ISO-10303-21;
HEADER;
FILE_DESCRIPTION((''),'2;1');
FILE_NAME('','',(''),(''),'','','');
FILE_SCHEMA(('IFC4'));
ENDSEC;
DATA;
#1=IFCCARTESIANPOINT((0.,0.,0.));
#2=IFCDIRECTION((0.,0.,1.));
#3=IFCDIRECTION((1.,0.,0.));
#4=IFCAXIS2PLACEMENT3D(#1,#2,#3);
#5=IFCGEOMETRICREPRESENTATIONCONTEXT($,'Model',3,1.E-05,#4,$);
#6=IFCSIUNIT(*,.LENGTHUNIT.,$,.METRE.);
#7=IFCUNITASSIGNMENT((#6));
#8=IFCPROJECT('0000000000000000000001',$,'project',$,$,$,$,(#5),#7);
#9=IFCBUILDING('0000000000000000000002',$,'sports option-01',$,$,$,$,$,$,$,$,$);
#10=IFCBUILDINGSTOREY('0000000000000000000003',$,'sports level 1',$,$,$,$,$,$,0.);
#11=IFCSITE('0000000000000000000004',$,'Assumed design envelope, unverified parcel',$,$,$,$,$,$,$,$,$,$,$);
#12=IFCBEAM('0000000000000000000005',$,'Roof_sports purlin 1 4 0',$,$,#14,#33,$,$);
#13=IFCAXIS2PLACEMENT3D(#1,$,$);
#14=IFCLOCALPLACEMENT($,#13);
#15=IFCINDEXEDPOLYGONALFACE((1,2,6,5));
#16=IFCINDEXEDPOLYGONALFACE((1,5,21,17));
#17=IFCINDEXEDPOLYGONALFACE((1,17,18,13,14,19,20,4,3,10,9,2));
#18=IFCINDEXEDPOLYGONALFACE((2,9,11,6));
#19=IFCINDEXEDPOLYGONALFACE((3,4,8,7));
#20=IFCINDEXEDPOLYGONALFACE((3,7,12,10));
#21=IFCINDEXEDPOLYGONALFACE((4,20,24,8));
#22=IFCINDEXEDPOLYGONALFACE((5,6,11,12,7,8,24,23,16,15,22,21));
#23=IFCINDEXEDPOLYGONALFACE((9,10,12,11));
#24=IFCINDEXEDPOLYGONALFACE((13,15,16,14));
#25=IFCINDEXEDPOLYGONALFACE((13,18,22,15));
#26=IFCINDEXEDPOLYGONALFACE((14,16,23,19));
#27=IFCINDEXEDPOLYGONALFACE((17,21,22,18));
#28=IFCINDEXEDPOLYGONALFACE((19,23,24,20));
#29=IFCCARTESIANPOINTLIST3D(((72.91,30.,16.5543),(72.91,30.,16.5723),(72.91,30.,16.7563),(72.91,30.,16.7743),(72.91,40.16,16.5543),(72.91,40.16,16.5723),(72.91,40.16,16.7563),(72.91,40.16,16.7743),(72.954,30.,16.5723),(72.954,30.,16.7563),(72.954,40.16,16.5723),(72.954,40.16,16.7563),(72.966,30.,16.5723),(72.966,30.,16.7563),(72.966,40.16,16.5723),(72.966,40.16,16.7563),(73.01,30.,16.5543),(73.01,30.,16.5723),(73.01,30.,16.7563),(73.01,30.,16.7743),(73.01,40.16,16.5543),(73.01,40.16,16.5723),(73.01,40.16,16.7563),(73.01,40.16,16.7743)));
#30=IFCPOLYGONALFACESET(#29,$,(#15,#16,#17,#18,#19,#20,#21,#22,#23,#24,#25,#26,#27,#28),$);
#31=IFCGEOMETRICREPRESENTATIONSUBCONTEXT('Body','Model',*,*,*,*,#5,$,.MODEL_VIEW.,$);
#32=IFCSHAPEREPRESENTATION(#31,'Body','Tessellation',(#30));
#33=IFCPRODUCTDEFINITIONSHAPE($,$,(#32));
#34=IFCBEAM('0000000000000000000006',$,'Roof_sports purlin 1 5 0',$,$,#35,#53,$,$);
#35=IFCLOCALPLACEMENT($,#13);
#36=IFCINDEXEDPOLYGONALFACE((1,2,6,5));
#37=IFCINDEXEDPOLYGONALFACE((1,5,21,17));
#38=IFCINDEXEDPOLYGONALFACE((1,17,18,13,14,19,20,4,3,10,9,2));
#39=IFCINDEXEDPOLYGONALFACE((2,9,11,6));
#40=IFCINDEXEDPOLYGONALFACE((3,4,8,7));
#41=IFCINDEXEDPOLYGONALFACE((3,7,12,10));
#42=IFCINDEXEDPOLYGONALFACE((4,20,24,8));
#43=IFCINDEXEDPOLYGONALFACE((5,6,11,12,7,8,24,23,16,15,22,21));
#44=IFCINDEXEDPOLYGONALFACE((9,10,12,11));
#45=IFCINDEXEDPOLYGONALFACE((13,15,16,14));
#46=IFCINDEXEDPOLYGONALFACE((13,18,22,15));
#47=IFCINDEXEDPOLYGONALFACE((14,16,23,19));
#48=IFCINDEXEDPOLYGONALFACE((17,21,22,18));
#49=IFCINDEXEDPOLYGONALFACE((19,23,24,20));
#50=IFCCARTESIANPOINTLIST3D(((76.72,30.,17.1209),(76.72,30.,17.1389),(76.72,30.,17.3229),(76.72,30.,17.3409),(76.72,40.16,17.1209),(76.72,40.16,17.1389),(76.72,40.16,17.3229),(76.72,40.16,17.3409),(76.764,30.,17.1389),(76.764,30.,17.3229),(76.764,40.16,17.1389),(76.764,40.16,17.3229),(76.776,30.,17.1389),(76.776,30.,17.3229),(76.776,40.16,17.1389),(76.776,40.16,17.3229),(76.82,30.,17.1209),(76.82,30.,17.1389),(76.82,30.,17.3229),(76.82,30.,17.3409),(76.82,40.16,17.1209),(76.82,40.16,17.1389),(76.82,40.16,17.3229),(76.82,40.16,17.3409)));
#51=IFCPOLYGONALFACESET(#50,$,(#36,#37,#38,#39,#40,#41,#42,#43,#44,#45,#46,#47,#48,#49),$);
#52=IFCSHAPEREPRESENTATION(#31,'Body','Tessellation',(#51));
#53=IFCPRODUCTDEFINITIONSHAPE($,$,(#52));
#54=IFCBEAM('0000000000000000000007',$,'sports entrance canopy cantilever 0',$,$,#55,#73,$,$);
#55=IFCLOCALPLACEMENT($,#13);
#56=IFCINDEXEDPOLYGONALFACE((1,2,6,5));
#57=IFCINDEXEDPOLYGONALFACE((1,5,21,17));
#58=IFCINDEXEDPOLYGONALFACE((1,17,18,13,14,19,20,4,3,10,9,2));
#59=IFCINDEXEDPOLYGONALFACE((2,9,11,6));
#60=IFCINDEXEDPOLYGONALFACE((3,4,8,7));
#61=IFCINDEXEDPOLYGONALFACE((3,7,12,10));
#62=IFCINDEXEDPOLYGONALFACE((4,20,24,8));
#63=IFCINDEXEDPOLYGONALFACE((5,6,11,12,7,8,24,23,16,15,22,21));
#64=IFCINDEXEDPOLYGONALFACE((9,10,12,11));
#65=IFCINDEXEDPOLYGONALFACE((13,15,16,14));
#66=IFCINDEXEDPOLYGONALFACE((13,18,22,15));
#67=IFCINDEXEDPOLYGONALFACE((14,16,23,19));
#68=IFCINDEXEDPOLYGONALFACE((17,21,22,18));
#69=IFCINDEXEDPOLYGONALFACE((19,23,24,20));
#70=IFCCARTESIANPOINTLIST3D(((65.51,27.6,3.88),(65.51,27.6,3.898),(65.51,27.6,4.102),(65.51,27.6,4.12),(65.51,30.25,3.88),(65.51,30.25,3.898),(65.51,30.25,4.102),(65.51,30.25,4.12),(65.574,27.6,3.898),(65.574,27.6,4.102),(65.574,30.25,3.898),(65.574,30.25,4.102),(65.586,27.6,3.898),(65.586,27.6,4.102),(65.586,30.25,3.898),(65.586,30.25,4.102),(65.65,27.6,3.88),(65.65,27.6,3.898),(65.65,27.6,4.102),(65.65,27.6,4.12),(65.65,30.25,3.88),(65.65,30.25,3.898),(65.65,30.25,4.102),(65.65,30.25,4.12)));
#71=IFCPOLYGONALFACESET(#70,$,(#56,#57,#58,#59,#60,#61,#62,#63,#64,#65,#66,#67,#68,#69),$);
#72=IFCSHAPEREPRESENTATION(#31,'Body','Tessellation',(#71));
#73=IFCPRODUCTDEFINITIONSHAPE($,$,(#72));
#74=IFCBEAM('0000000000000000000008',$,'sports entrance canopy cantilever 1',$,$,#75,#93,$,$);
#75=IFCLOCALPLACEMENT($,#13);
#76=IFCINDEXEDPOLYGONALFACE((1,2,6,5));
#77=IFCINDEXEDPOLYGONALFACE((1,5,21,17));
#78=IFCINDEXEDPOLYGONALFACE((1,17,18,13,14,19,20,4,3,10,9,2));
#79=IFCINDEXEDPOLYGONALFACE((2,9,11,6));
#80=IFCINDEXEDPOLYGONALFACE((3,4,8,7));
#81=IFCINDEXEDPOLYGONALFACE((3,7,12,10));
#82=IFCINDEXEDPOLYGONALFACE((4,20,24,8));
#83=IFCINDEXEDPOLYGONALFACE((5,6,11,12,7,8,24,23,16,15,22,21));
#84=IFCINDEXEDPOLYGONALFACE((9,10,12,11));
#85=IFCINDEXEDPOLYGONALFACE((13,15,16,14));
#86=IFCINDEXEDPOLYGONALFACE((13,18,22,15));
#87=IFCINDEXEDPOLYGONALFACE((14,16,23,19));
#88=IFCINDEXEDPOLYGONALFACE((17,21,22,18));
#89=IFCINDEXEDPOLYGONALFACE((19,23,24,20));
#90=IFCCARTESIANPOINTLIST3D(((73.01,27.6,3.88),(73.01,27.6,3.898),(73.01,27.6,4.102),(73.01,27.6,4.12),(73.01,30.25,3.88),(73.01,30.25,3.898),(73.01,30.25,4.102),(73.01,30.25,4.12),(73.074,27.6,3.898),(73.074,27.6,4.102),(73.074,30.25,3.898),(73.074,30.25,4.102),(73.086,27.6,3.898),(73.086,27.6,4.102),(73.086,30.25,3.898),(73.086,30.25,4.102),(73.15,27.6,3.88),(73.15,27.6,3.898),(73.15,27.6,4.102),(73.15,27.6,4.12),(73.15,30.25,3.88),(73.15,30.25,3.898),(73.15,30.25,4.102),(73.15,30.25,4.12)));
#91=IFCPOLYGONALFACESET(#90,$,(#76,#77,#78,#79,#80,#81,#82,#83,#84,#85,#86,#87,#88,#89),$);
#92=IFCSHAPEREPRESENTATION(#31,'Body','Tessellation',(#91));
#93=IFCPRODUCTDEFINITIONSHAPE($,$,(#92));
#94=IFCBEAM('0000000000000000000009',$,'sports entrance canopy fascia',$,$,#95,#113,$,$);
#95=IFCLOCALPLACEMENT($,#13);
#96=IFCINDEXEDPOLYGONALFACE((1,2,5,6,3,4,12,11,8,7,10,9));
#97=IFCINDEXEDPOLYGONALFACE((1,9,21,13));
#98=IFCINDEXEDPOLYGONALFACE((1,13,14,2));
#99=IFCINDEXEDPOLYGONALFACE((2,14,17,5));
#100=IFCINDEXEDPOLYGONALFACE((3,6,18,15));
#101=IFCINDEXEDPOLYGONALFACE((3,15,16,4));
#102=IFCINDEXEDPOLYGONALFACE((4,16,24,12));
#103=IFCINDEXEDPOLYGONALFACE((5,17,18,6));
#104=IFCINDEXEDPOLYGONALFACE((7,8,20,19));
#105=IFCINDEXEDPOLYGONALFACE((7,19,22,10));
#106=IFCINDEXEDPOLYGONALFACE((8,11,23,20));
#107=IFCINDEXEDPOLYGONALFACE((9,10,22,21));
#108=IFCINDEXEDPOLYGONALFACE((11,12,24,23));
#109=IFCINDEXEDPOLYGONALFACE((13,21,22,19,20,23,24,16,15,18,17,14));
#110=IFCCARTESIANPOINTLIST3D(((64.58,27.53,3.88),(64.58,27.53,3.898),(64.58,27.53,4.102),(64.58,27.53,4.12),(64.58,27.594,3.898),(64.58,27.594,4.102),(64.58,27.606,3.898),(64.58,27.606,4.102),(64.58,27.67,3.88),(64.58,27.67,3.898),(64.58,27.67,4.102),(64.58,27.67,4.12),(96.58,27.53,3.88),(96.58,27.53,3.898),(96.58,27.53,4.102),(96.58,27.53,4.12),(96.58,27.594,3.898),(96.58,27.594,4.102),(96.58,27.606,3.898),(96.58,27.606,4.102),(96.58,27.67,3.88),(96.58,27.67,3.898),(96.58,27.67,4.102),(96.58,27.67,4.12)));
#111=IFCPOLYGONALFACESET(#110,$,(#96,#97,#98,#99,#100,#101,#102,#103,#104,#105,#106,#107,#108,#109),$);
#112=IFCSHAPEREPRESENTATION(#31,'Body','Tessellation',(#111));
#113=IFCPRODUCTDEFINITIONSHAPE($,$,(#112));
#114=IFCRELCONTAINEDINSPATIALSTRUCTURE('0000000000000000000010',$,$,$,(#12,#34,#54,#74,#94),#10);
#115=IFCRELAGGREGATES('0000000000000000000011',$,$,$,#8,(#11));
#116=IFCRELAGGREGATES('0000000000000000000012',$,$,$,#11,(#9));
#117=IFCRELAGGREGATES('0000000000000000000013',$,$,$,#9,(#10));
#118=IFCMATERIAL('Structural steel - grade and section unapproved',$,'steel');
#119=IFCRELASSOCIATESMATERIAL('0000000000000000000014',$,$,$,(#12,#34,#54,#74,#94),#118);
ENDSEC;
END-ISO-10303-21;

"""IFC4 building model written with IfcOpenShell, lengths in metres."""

from ifc_helpers import new_model, si_unit, frame, origin_with_axes, place, context, subcontext, project, spatial, i_section, extrude, material, element, save


model = new_model("IFC4")

# Units and contexts
model_context = context("Model", 3, precision=1e-05, world=origin_with_axes())
body_context = subcontext(model_context, "Body", "Model", "MODEL_VIEW")
ifc_project = project(units=[si_unit("LENGTHUNIT", "METRE")], contexts=[model_context])

# Site, building, storey
site = spatial("IfcSite", under=ifc_project, Name="Assumed design envelope, unverified parcel")
building = spatial("IfcBuilding", under=site, Name="sports option-01")
storey = spatial("IfcBuildingStorey", under=building, Name="sports level 1", Elevation=0.0)

# Shared definitions
ifc_material = material(Name="Structural steel - grade and section unapproved", Category="steel")

# Beams
for number, where, z_axis, x_axis, name in (
    (1, (72.96, 30.0, 16.6643), (0.0, 1.0, 0.0), (-1.0, 0.0, 0.0), "Roof_sports purlin 1 4 0"),
    (2, (76.77, 30.0, 17.2309), (0.0, 1.0, 0.0), (-1.0, 0.0, 0.0), "Roof_sports purlin 1 5 0"),
):
    element("IfcBeam", number, at=place(None, frame(where, z_axis=z_axis, x_axis=x_axis)), inside=storey, material=ifc_material, Name=name, context=body_context, shape_type="SweptSolid", body=[
        extrude(i_section(OverallWidth=0.1, OverallDepth=0.22, WebThickness=0.012, FlangeThickness=0.018, FilletRadius=0.0), origin_with_axes(), (0.0, 0.0, 1.0), 10.16),
    ])
for number, where, z_axis, x_axis, name in (
    (3, (65.58, 30.25, 4.0), (0.0, -1.0, 0.0), (1.0, 0.0, 0.0), "sports entrance canopy cantilever 0"),
    (4, (73.08, 30.25, 4.0), (0.0, -1.0, 0.0), (1.0, 0.0, 0.0), "sports entrance canopy cantilever 1"),
):
    element("IfcBeam", number, at=place(None, frame(where, z_axis=z_axis, x_axis=x_axis)), inside=storey, material=ifc_material, Name=name, context=body_context, shape_type="SweptSolid", body=[
        extrude(i_section(OverallWidth=0.14, OverallDepth=0.24, WebThickness=0.012, FlangeThickness=0.018, FilletRadius=0.0), origin_with_axes(), (0.0, 0.0, 1.0), 2.65),
    ])
beam_1_placement = place(None, frame((64.58, 27.6, 4.0), z_axis=(1.0, 0.0, 0.0), x_axis=(0.0, 1.0, 0.0)))
element("IfcBeam", 5, at=beam_1_placement, inside=storey, material=ifc_material, Name="sports entrance canopy fascia", context=body_context, shape_type="SweptSolid", body=[
    extrude(i_section(OverallWidth=0.14, OverallDepth=0.24, WebThickness=0.012, FlangeThickness=0.018, FilletRadius=0.0), origin_with_axes(), (0.0, 0.0, 1.0), 32.0),
])

save(model, "model.ifc")
